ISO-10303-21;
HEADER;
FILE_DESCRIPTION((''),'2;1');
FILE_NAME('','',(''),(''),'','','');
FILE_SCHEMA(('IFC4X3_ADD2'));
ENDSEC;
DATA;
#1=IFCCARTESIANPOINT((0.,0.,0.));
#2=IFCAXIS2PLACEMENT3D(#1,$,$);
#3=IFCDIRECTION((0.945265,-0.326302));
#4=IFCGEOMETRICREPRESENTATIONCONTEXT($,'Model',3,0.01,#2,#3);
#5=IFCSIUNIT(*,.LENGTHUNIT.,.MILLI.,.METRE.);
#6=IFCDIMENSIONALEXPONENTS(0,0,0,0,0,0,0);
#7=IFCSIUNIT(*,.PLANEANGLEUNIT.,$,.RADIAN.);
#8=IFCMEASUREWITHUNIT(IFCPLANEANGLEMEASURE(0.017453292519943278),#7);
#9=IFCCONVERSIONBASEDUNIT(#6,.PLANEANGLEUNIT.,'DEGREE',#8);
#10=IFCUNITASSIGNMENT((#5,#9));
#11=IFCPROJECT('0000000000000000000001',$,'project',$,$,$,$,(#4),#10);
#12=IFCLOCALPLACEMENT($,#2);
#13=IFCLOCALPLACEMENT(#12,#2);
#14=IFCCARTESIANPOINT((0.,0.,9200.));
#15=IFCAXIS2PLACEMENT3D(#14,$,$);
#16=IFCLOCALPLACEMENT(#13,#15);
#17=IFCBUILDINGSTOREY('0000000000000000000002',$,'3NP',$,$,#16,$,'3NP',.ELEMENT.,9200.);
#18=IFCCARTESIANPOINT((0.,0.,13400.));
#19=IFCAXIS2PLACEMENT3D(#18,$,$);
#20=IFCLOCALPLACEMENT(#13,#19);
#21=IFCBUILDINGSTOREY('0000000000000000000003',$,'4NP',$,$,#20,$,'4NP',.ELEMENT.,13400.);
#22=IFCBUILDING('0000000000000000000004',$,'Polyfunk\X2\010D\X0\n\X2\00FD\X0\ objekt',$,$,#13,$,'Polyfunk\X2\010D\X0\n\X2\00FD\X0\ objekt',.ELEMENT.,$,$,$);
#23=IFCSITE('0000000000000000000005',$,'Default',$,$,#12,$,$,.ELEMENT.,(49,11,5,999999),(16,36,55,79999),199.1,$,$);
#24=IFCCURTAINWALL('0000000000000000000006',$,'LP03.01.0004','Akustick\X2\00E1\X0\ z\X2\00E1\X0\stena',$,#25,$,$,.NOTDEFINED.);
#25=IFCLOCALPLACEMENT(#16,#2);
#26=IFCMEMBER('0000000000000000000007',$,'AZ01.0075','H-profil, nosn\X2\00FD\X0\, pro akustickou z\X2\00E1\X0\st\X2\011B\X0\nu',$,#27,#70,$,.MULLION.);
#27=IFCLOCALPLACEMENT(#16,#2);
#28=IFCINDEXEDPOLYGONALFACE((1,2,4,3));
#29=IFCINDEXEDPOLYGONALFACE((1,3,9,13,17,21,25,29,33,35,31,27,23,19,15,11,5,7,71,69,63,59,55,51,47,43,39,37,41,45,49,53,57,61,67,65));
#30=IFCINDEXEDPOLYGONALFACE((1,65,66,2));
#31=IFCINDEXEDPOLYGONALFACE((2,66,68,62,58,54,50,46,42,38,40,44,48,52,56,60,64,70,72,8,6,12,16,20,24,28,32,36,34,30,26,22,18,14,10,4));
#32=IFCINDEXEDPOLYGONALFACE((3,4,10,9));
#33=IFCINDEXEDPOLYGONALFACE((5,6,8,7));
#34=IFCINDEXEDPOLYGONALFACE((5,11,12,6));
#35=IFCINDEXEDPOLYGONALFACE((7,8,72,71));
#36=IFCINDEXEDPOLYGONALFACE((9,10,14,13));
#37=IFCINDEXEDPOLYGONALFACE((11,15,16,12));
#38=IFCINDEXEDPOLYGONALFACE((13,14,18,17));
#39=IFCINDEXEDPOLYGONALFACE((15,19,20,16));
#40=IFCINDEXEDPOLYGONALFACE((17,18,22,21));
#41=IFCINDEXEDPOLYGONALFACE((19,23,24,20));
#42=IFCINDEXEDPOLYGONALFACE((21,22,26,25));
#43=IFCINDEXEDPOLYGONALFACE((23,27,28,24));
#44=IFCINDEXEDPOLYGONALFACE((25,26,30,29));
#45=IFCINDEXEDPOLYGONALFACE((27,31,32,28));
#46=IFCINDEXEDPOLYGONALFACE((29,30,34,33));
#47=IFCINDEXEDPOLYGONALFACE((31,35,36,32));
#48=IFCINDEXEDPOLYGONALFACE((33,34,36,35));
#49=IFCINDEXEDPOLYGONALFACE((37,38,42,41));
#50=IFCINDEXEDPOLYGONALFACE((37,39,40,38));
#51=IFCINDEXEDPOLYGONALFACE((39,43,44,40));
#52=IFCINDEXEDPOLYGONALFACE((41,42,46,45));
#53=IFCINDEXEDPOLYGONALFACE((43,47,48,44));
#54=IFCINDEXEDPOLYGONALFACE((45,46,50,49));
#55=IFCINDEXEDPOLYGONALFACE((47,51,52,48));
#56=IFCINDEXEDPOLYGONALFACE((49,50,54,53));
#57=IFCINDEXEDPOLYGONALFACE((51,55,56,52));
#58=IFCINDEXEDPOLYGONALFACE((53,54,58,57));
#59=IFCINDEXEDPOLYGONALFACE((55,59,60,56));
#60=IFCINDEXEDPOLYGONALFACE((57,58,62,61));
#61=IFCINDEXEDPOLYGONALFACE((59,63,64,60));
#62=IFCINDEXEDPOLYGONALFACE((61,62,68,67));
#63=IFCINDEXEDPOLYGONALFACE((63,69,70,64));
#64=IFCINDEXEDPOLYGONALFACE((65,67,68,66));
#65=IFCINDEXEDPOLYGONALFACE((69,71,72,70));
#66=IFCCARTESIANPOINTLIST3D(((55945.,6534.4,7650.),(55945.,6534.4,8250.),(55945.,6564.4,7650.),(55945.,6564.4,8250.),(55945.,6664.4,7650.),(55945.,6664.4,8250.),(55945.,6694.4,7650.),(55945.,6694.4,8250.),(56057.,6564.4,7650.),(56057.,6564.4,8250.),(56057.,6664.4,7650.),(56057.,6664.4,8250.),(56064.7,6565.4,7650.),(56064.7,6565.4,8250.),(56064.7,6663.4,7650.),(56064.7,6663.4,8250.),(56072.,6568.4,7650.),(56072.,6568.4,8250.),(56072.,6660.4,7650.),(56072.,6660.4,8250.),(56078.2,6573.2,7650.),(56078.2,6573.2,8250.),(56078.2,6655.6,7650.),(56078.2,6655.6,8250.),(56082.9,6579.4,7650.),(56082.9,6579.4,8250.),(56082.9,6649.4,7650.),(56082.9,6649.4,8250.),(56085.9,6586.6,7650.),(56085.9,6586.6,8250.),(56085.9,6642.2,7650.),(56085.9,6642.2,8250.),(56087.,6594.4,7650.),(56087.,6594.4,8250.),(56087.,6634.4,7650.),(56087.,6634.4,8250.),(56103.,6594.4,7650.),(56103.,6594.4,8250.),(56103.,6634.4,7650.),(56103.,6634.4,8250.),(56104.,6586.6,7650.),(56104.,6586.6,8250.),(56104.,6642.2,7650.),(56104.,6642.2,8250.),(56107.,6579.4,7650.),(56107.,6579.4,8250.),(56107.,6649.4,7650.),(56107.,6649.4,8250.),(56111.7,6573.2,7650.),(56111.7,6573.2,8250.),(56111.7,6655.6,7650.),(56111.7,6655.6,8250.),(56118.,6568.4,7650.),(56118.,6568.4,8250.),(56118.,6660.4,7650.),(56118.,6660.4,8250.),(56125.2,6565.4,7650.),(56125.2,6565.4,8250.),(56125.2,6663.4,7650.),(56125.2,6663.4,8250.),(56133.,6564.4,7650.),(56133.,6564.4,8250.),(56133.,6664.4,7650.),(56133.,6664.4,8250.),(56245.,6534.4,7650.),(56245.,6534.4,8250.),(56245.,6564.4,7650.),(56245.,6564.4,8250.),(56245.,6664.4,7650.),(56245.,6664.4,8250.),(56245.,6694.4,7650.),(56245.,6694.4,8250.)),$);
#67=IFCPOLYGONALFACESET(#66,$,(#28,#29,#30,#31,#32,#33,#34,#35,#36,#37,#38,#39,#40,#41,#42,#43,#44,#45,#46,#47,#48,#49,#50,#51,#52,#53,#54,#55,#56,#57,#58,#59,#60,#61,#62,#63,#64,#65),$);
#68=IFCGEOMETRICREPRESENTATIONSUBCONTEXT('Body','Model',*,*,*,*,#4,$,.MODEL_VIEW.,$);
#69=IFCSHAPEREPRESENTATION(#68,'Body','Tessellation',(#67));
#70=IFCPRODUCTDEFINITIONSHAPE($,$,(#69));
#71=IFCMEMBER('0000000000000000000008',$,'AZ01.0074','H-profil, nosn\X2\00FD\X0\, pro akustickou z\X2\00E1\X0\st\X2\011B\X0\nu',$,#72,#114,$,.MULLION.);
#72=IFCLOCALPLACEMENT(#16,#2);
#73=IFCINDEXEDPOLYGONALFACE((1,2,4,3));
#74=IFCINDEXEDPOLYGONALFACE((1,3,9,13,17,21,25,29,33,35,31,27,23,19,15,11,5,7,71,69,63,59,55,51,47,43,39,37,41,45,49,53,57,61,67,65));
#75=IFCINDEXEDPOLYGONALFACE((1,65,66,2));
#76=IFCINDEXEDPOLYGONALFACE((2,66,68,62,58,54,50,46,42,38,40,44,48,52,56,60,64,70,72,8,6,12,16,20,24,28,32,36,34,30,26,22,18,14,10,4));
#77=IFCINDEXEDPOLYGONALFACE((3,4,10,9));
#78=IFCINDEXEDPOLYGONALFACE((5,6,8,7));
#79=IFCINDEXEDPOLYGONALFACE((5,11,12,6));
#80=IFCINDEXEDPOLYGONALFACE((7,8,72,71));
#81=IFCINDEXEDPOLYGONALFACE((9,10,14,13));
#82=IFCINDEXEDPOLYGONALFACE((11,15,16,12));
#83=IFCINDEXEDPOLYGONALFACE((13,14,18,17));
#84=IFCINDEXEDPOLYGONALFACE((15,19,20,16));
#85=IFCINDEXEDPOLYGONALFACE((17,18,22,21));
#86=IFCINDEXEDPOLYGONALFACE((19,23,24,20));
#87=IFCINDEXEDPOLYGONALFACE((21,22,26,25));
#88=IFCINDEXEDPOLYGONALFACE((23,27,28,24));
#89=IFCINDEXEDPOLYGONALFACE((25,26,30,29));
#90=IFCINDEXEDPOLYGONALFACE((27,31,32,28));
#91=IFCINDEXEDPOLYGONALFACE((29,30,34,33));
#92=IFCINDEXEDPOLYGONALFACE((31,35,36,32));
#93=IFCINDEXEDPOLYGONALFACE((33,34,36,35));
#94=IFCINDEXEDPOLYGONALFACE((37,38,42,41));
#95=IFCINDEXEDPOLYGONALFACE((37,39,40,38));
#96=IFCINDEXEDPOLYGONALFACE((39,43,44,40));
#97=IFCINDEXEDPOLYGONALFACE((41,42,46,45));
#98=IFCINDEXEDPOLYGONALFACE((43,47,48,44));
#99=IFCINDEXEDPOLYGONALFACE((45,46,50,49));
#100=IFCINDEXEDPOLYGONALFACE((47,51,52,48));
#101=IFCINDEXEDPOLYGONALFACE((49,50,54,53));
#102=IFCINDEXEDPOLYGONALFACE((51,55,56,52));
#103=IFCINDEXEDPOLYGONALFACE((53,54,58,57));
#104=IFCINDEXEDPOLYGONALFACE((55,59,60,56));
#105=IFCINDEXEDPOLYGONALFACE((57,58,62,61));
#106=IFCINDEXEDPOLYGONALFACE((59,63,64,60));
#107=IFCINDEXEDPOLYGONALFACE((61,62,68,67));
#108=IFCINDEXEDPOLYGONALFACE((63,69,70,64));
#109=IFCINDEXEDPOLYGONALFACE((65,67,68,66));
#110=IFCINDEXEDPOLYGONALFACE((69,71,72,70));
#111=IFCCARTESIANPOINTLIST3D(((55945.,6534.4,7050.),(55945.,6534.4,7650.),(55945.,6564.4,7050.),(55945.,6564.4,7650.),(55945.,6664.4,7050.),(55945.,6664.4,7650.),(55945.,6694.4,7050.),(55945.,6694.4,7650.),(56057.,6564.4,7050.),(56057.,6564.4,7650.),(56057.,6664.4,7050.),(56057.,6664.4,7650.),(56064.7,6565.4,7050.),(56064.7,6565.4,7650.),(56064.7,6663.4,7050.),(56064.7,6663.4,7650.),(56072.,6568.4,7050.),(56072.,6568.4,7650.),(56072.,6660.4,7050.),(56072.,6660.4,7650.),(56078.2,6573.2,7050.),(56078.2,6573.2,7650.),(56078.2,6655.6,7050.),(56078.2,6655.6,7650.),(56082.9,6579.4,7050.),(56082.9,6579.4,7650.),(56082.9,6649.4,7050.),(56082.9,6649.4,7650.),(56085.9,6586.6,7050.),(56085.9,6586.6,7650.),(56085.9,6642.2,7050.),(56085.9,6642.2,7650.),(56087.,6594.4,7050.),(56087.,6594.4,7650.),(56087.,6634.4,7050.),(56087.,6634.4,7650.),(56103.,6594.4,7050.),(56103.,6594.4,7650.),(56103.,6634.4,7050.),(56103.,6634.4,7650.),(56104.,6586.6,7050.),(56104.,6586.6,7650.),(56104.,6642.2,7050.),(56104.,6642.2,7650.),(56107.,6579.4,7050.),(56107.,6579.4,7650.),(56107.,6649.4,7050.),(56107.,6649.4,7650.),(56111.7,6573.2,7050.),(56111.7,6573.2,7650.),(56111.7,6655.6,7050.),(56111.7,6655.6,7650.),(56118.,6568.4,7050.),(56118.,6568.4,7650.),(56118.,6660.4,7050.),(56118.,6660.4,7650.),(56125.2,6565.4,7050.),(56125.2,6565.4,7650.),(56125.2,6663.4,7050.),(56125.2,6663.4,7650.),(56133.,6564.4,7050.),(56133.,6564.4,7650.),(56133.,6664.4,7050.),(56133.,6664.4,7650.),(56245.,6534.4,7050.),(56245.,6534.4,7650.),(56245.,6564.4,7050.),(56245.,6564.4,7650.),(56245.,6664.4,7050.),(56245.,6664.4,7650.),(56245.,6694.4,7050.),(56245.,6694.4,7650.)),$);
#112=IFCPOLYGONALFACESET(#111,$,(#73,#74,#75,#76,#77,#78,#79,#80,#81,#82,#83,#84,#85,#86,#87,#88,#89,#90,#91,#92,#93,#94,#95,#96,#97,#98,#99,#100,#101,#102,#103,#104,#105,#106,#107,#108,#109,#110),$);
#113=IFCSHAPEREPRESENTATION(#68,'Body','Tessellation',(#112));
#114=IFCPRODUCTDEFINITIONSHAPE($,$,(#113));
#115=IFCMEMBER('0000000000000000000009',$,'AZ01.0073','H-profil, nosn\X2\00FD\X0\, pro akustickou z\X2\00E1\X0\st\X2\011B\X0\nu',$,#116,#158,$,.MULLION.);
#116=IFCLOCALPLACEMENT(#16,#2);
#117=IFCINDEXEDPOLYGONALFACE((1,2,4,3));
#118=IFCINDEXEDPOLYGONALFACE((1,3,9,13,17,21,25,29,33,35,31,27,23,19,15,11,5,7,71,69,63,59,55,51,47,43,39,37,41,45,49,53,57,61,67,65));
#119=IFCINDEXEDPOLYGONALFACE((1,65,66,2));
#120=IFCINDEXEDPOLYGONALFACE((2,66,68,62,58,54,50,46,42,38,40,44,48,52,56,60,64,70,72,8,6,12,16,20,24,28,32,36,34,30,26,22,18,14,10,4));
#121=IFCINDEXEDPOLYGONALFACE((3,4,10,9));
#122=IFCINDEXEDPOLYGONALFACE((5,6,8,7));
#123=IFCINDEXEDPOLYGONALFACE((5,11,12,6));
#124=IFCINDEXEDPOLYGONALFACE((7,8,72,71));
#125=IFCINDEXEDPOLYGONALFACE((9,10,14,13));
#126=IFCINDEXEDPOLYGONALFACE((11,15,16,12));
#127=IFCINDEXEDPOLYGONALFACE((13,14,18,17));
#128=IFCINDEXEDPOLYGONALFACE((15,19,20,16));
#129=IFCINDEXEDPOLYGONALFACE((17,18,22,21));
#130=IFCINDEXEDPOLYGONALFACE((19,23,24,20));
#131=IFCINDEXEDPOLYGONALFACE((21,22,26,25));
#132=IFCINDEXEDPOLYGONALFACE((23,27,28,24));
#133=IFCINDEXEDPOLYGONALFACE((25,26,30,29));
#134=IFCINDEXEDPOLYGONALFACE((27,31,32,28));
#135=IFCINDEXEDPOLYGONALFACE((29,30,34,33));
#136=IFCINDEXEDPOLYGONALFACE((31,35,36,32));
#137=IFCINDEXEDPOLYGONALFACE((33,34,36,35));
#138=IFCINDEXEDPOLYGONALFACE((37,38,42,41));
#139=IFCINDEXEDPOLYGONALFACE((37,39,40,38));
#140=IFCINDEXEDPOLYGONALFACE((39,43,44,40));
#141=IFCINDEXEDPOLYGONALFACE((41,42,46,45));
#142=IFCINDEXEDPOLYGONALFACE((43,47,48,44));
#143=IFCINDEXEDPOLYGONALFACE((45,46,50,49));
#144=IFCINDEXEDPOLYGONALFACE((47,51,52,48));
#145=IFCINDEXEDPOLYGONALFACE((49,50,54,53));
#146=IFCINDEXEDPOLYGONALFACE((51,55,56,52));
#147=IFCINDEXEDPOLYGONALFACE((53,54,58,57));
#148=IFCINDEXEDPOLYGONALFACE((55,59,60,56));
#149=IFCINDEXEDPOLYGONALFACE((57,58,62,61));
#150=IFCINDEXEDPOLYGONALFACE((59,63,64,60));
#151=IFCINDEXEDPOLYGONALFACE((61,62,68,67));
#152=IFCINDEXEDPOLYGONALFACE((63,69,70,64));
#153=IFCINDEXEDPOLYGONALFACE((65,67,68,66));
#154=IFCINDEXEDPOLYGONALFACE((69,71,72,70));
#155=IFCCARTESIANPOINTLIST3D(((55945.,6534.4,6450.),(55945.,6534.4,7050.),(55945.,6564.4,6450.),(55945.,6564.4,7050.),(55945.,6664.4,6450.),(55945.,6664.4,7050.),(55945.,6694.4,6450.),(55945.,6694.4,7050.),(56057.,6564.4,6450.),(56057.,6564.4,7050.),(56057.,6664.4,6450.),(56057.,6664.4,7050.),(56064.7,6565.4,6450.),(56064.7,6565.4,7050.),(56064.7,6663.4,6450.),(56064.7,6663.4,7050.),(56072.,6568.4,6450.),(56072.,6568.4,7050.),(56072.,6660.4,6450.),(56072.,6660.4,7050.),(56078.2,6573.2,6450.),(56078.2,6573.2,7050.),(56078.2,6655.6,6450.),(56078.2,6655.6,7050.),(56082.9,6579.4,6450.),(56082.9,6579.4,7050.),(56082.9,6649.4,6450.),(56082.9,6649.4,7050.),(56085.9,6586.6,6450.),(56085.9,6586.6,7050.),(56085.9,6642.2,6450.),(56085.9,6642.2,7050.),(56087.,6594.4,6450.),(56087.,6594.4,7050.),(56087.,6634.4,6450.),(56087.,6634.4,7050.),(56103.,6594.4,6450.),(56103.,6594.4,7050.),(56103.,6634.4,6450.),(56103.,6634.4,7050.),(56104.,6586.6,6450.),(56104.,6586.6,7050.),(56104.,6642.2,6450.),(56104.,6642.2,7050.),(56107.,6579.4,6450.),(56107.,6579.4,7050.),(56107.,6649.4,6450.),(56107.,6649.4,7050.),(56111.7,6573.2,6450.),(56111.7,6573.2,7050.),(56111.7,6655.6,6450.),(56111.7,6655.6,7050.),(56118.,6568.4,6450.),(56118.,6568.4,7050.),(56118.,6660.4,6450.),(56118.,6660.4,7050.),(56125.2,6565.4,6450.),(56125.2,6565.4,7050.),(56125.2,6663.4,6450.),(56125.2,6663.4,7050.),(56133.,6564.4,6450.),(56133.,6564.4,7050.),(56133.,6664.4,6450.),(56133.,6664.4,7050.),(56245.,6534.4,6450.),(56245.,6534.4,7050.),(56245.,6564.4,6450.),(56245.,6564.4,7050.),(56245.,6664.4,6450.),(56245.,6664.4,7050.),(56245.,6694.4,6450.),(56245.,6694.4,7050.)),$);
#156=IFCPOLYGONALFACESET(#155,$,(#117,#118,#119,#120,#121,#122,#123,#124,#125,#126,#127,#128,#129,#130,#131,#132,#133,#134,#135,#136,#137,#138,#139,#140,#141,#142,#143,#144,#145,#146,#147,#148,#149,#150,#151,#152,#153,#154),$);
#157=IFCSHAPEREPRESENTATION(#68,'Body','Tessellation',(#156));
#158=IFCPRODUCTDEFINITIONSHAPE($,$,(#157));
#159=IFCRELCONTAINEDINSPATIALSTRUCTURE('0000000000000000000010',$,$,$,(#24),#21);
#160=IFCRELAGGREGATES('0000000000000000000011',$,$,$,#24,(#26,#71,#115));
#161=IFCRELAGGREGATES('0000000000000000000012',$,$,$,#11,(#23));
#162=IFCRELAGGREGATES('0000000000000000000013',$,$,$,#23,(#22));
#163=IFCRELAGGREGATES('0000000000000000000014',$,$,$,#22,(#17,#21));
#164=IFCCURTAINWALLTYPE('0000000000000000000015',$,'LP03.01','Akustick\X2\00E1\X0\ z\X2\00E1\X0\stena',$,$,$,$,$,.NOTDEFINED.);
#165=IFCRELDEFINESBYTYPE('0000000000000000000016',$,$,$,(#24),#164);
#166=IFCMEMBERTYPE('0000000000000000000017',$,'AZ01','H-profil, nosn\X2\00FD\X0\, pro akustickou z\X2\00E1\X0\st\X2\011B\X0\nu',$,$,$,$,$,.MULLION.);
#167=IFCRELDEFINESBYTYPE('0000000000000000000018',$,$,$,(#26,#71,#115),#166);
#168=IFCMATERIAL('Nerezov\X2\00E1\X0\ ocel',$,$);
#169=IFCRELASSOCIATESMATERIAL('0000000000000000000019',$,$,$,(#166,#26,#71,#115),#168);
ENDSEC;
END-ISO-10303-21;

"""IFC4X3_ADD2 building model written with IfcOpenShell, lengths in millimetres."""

from ifc_helpers import new_model, entity, si_unit, converted_unit, direction, frame, frame_2d, origin, place, context, subcontext, project, spatial, polyline, circle_curve, parameter, trimmed, segment, composite_curve, outline, extrude, source, transform, mapped, material, material_profile, profile_set, profile_usage, type_object, element, aggregate, save


model = new_model("IFC4X3_ADD2")

# Units and contexts
model_context = context("Model", 3, precision=0.01, world=origin(), true_north=direction((0.945265, -0.326302)))
body_context = subcontext(model_context, "Body", "Model", "MODEL_VIEW")
ifc_project = project(units=[si_unit("LENGTHUNIT", "METRE", prefix="MILLI"), converted_unit("PLANEANGLEUNIT", "DEGREE", entity("IfcPlaneAngleMeasure", 0.017453292519943278), si_unit("PLANEANGLEUNIT", "RADIAN"), dimensions=[0, 0, 0, 0, 0, 0, 0])], contexts=[model_context])

# Site, building, storey
site_placement = place(None, origin())
site = spatial("IfcSite", under=ifc_project, at=site_placement, Name="Default", CompositionType="ELEMENT", RefLatitude=(49, 11, 5, 999999), RefLongitude=(16, 36, 55, 79999), RefElevation=199.1)
building_placement = place(site_placement, origin())
building = spatial("IfcBuilding", under=site, at=building_placement, Name="Polyfunkčný objekt", LongName="Polyfunkčný objekt", CompositionType="ELEMENT")
storey_1_placement = place(building_placement, frame((0.0, 0.0, 9200.0)))
storey_1 = spatial("IfcBuildingStorey", under=building, at=storey_1_placement, Name="3NP", LongName="3NP", CompositionType="ELEMENT", Elevation=9200.0)

# Shared definitions
storey_2_placement = place(building_placement, frame((0.0, 0.0, 13400.0)))
storey_2 = spatial("IfcBuildingStorey", under=building, at=storey_2_placement, Name="4NP", LongName="4NP", CompositionType="ELEMENT", Elevation=13400.0)

# Curtain wall, members
curtain_wall_type_1 = type_object("IfcCurtainWallType", Name="LP03.01", Description="Akustická zástena", PredefinedType="NOTDEFINED")
curtain_wall_1_placement = place(storey_2_placement, frame((0.0, 0.0, -13400.0)))
curtain_wall_1 = element("IfcCurtainWall", 1, at=curtain_wall_1_placement, inside=storey_2, type_object=curtain_wall_type_1, Name="LP03.01.0004", Description="Akustická zástena", PredefinedType="NOTDEFINED")
ifc_material_1 = material(Name="Nerezová ocel")
ifc_material_profile_1 = material_profile(ifc_material_1, outline(composite_curve([segment(polyline([(50.0, -150.0), (80.0, -150.0)]), True, "CONTINUOUS"), segment(polyline([(80.0, -150.0), (80.0, 150.0)]), True, "CONTINUOUS"), segment(polyline([(80.0, 150.0), (50.0, 150.0)]), True, "CONTINUOUS"), segment(polyline([(50.0, 150.0), (50.0, 38.0)]), True, "CONTINUOUS"), segment(trimmed(circle_curve(frame_2d((20.0, 38.0), x_axis=(0.0, 1.0)), 30.0), [parameter(180.0)], [parameter(270.0)], True, "PARAMETER"), False, "CONTINUOUS"), segment(polyline([(20.0, 8.0), (-20.0, 8.0)]), True, "CONTINUOUS"), segment(trimmed(circle_curve(frame_2d((-20.0, 38.0), x_axis=(0.0, 1.0)), 30.0), [parameter(90.0)], [parameter(180.0)], True, "PARAMETER"), False, "CONTINUOUS"), segment(polyline([(-50.0, 38.0), (-50.0, 150.0)]), True, "CONTINUOUS"), segment(polyline([(-50.0, 150.0), (-80.0, 150.0)]), True, "CONTINUOUS"), segment(polyline([(-80.0, 150.0), (-80.0, -150.0)]), True, "CONTINUOUS"), segment(polyline([(-80.0, -150.0), (-50.0, -150.0)]), True, "CONTINUOUS"), segment(polyline([(-50.0, -150.0), (-50.0, -38.0)]), True, "CONTINUOUS"), segment(trimmed(circle_curve(frame_2d((-20.0, -38.0), x_axis=(0.0, 1.0)), 30.0), [parameter(0.0)], [parameter(90.0)], True, "PARAMETER"), False, "CONTINUOUS"), segment(polyline([(-20.0, -8.0), (20.0, -8.0)]), True, "CONTINUOUS"), segment(trimmed(circle_curve(frame_2d((20.0, -38.0), x_axis=(0.0, 1.0)), 30.0), [parameter(270.0)], [parameter(0.0)], True, "PARAMETER"), False, "CONTINUOUS"), segment(polyline([(50.0, -38.0), (50.0, -150.0)]), True, "CONTINUOUS")], self_intersect=False)), Name="Profil zástena")
ifc_profile_set_1 = profile_set([ifc_material_profile_1], Name="Profil zástena")
ifc_profile_usage_1 = profile_usage(ifc_profile_set_1)
member_type_1 = type_object("IfcMemberType", Name="AZ01", Description="H-profil, nosný, pro akustickou zástěnu", PredefinedType="MULLION", material=ifc_profile_set_1)
shared_shape_1 = source(origin(), body_context, "Body", "SweptSolid", [
    extrude(outline(composite_curve([segment(polyline([(50.0, -150.0), (80.0, -150.0)]), True, "CONTINUOUS"), segment(polyline([(80.0, -150.0), (80.0, 150.0)]), True, "CONTINUOUS"), segment(polyline([(80.0, 150.0), (50.0, 150.0)]), True, "CONTINUOUS"), segment(polyline([(50.0, 150.0), (50.0, 38.0)]), True, "CONTINUOUS"), segment(trimmed(circle_curve(frame_2d((20.0, 38.0), x_axis=(0.0, 1.0)), 30.0), [parameter(180.0)], [parameter(270.0)], True, "PARAMETER"), False, "CONTINUOUS"), segment(polyline([(20.0, 8.0), (-20.0, 8.0)]), True, "CONTINUOUS"), segment(trimmed(circle_curve(frame_2d((-20.0, 38.0), x_axis=(0.0, 1.0)), 30.0), [parameter(90.0)], [parameter(180.0)], True, "PARAMETER"), False, "CONTINUOUS"), segment(polyline([(-50.0, 38.0), (-50.0, 150.0)]), True, "CONTINUOUS"), segment(polyline([(-50.0, 150.0), (-80.0, 150.0)]), True, "CONTINUOUS"), segment(polyline([(-80.0, 150.0), (-80.0, -150.0)]), True, "CONTINUOUS"), segment(polyline([(-80.0, -150.0), (-50.0, -150.0)]), True, "CONTINUOUS"), segment(polyline([(-50.0, -150.0), (-50.0, -38.0)]), True, "CONTINUOUS"), segment(trimmed(circle_curve(frame_2d((-20.0, -38.0), x_axis=(0.0, 1.0)), 30.0), [parameter(0.0)], [parameter(90.0)], True, "PARAMETER"), False, "CONTINUOUS"), segment(polyline([(-20.0, -8.0), (20.0, -8.0)]), True, "CONTINUOUS"), segment(trimmed(circle_curve(frame_2d((20.0, -38.0), x_axis=(0.0, 1.0)), 30.0), [parameter(270.0)], [parameter(0.0)], True, "PARAMETER"), False, "CONTINUOUS"), segment(polyline([(50.0, -38.0), (50.0, -150.0)]), True, "CONTINUOUS")], self_intersect=False)), frame((-150.0, 0.0, -600.0), z_axis=(0.0, 0.0, 1.0), x_axis=(0.0, -1.0, 0.0)), (0.0, 0.0, 1.0), 600.0),
])
member_1_placement = place(curtain_wall_1_placement, frame((56245.0, 6614.4, 16850.0), z_axis=(0.0, 0.0, -1.0), x_axis=(1.0, 0.0, 0.0)))
member_1 = element("IfcMember", 2, at=member_1_placement, type_object=member_type_1, material=ifc_profile_usage_1, Name="AZ01.0075", Description="H-profil, nosný, pro akustickou zástěnu", PredefinedType="MULLION", context=body_context, shape_type="MappedRepresentation", body=[
    mapped(shared_shape_1, transform((0.0, 0.0, 0.0), scale=1.0)),
])
member_2_placement = place(curtain_wall_1_placement, frame((56245.0, 6614.4, 16250.0), z_axis=(0.0, 0.0, -1.0), x_axis=(1.0, 0.0, 0.0)))
member_2 = element("IfcMember", 3, at=member_2_placement, type_object=member_type_1, material=ifc_profile_usage_1, Name="AZ01.0074", Description="H-profil, nosný, pro akustickou zástěnu", PredefinedType="MULLION", context=body_context, shape_type="MappedRepresentation", body=[
    mapped(shared_shape_1, transform((0.0, 0.0, 0.0), scale=1.0)),
])
member_3_placement = place(curtain_wall_1_placement, frame((56245.0, 6614.4, 15650.0), z_axis=(0.0, 0.0, -1.0), x_axis=(1.0, 0.0, 0.0)))
member_3 = element("IfcMember", 4, at=member_3_placement, type_object=member_type_1, material=ifc_profile_usage_1, Name="AZ01.0073", Description="H-profil, nosný, pro akustickou zástěnu", PredefinedType="MULLION", context=body_context, shape_type="MappedRepresentation", body=[
    mapped(shared_shape_1, transform((0.0, 0.0, 0.0), scale=1.0)),
])
aggregate(curtain_wall_1, [member_1, member_2, member_3])

save(model, "model.ifc")
